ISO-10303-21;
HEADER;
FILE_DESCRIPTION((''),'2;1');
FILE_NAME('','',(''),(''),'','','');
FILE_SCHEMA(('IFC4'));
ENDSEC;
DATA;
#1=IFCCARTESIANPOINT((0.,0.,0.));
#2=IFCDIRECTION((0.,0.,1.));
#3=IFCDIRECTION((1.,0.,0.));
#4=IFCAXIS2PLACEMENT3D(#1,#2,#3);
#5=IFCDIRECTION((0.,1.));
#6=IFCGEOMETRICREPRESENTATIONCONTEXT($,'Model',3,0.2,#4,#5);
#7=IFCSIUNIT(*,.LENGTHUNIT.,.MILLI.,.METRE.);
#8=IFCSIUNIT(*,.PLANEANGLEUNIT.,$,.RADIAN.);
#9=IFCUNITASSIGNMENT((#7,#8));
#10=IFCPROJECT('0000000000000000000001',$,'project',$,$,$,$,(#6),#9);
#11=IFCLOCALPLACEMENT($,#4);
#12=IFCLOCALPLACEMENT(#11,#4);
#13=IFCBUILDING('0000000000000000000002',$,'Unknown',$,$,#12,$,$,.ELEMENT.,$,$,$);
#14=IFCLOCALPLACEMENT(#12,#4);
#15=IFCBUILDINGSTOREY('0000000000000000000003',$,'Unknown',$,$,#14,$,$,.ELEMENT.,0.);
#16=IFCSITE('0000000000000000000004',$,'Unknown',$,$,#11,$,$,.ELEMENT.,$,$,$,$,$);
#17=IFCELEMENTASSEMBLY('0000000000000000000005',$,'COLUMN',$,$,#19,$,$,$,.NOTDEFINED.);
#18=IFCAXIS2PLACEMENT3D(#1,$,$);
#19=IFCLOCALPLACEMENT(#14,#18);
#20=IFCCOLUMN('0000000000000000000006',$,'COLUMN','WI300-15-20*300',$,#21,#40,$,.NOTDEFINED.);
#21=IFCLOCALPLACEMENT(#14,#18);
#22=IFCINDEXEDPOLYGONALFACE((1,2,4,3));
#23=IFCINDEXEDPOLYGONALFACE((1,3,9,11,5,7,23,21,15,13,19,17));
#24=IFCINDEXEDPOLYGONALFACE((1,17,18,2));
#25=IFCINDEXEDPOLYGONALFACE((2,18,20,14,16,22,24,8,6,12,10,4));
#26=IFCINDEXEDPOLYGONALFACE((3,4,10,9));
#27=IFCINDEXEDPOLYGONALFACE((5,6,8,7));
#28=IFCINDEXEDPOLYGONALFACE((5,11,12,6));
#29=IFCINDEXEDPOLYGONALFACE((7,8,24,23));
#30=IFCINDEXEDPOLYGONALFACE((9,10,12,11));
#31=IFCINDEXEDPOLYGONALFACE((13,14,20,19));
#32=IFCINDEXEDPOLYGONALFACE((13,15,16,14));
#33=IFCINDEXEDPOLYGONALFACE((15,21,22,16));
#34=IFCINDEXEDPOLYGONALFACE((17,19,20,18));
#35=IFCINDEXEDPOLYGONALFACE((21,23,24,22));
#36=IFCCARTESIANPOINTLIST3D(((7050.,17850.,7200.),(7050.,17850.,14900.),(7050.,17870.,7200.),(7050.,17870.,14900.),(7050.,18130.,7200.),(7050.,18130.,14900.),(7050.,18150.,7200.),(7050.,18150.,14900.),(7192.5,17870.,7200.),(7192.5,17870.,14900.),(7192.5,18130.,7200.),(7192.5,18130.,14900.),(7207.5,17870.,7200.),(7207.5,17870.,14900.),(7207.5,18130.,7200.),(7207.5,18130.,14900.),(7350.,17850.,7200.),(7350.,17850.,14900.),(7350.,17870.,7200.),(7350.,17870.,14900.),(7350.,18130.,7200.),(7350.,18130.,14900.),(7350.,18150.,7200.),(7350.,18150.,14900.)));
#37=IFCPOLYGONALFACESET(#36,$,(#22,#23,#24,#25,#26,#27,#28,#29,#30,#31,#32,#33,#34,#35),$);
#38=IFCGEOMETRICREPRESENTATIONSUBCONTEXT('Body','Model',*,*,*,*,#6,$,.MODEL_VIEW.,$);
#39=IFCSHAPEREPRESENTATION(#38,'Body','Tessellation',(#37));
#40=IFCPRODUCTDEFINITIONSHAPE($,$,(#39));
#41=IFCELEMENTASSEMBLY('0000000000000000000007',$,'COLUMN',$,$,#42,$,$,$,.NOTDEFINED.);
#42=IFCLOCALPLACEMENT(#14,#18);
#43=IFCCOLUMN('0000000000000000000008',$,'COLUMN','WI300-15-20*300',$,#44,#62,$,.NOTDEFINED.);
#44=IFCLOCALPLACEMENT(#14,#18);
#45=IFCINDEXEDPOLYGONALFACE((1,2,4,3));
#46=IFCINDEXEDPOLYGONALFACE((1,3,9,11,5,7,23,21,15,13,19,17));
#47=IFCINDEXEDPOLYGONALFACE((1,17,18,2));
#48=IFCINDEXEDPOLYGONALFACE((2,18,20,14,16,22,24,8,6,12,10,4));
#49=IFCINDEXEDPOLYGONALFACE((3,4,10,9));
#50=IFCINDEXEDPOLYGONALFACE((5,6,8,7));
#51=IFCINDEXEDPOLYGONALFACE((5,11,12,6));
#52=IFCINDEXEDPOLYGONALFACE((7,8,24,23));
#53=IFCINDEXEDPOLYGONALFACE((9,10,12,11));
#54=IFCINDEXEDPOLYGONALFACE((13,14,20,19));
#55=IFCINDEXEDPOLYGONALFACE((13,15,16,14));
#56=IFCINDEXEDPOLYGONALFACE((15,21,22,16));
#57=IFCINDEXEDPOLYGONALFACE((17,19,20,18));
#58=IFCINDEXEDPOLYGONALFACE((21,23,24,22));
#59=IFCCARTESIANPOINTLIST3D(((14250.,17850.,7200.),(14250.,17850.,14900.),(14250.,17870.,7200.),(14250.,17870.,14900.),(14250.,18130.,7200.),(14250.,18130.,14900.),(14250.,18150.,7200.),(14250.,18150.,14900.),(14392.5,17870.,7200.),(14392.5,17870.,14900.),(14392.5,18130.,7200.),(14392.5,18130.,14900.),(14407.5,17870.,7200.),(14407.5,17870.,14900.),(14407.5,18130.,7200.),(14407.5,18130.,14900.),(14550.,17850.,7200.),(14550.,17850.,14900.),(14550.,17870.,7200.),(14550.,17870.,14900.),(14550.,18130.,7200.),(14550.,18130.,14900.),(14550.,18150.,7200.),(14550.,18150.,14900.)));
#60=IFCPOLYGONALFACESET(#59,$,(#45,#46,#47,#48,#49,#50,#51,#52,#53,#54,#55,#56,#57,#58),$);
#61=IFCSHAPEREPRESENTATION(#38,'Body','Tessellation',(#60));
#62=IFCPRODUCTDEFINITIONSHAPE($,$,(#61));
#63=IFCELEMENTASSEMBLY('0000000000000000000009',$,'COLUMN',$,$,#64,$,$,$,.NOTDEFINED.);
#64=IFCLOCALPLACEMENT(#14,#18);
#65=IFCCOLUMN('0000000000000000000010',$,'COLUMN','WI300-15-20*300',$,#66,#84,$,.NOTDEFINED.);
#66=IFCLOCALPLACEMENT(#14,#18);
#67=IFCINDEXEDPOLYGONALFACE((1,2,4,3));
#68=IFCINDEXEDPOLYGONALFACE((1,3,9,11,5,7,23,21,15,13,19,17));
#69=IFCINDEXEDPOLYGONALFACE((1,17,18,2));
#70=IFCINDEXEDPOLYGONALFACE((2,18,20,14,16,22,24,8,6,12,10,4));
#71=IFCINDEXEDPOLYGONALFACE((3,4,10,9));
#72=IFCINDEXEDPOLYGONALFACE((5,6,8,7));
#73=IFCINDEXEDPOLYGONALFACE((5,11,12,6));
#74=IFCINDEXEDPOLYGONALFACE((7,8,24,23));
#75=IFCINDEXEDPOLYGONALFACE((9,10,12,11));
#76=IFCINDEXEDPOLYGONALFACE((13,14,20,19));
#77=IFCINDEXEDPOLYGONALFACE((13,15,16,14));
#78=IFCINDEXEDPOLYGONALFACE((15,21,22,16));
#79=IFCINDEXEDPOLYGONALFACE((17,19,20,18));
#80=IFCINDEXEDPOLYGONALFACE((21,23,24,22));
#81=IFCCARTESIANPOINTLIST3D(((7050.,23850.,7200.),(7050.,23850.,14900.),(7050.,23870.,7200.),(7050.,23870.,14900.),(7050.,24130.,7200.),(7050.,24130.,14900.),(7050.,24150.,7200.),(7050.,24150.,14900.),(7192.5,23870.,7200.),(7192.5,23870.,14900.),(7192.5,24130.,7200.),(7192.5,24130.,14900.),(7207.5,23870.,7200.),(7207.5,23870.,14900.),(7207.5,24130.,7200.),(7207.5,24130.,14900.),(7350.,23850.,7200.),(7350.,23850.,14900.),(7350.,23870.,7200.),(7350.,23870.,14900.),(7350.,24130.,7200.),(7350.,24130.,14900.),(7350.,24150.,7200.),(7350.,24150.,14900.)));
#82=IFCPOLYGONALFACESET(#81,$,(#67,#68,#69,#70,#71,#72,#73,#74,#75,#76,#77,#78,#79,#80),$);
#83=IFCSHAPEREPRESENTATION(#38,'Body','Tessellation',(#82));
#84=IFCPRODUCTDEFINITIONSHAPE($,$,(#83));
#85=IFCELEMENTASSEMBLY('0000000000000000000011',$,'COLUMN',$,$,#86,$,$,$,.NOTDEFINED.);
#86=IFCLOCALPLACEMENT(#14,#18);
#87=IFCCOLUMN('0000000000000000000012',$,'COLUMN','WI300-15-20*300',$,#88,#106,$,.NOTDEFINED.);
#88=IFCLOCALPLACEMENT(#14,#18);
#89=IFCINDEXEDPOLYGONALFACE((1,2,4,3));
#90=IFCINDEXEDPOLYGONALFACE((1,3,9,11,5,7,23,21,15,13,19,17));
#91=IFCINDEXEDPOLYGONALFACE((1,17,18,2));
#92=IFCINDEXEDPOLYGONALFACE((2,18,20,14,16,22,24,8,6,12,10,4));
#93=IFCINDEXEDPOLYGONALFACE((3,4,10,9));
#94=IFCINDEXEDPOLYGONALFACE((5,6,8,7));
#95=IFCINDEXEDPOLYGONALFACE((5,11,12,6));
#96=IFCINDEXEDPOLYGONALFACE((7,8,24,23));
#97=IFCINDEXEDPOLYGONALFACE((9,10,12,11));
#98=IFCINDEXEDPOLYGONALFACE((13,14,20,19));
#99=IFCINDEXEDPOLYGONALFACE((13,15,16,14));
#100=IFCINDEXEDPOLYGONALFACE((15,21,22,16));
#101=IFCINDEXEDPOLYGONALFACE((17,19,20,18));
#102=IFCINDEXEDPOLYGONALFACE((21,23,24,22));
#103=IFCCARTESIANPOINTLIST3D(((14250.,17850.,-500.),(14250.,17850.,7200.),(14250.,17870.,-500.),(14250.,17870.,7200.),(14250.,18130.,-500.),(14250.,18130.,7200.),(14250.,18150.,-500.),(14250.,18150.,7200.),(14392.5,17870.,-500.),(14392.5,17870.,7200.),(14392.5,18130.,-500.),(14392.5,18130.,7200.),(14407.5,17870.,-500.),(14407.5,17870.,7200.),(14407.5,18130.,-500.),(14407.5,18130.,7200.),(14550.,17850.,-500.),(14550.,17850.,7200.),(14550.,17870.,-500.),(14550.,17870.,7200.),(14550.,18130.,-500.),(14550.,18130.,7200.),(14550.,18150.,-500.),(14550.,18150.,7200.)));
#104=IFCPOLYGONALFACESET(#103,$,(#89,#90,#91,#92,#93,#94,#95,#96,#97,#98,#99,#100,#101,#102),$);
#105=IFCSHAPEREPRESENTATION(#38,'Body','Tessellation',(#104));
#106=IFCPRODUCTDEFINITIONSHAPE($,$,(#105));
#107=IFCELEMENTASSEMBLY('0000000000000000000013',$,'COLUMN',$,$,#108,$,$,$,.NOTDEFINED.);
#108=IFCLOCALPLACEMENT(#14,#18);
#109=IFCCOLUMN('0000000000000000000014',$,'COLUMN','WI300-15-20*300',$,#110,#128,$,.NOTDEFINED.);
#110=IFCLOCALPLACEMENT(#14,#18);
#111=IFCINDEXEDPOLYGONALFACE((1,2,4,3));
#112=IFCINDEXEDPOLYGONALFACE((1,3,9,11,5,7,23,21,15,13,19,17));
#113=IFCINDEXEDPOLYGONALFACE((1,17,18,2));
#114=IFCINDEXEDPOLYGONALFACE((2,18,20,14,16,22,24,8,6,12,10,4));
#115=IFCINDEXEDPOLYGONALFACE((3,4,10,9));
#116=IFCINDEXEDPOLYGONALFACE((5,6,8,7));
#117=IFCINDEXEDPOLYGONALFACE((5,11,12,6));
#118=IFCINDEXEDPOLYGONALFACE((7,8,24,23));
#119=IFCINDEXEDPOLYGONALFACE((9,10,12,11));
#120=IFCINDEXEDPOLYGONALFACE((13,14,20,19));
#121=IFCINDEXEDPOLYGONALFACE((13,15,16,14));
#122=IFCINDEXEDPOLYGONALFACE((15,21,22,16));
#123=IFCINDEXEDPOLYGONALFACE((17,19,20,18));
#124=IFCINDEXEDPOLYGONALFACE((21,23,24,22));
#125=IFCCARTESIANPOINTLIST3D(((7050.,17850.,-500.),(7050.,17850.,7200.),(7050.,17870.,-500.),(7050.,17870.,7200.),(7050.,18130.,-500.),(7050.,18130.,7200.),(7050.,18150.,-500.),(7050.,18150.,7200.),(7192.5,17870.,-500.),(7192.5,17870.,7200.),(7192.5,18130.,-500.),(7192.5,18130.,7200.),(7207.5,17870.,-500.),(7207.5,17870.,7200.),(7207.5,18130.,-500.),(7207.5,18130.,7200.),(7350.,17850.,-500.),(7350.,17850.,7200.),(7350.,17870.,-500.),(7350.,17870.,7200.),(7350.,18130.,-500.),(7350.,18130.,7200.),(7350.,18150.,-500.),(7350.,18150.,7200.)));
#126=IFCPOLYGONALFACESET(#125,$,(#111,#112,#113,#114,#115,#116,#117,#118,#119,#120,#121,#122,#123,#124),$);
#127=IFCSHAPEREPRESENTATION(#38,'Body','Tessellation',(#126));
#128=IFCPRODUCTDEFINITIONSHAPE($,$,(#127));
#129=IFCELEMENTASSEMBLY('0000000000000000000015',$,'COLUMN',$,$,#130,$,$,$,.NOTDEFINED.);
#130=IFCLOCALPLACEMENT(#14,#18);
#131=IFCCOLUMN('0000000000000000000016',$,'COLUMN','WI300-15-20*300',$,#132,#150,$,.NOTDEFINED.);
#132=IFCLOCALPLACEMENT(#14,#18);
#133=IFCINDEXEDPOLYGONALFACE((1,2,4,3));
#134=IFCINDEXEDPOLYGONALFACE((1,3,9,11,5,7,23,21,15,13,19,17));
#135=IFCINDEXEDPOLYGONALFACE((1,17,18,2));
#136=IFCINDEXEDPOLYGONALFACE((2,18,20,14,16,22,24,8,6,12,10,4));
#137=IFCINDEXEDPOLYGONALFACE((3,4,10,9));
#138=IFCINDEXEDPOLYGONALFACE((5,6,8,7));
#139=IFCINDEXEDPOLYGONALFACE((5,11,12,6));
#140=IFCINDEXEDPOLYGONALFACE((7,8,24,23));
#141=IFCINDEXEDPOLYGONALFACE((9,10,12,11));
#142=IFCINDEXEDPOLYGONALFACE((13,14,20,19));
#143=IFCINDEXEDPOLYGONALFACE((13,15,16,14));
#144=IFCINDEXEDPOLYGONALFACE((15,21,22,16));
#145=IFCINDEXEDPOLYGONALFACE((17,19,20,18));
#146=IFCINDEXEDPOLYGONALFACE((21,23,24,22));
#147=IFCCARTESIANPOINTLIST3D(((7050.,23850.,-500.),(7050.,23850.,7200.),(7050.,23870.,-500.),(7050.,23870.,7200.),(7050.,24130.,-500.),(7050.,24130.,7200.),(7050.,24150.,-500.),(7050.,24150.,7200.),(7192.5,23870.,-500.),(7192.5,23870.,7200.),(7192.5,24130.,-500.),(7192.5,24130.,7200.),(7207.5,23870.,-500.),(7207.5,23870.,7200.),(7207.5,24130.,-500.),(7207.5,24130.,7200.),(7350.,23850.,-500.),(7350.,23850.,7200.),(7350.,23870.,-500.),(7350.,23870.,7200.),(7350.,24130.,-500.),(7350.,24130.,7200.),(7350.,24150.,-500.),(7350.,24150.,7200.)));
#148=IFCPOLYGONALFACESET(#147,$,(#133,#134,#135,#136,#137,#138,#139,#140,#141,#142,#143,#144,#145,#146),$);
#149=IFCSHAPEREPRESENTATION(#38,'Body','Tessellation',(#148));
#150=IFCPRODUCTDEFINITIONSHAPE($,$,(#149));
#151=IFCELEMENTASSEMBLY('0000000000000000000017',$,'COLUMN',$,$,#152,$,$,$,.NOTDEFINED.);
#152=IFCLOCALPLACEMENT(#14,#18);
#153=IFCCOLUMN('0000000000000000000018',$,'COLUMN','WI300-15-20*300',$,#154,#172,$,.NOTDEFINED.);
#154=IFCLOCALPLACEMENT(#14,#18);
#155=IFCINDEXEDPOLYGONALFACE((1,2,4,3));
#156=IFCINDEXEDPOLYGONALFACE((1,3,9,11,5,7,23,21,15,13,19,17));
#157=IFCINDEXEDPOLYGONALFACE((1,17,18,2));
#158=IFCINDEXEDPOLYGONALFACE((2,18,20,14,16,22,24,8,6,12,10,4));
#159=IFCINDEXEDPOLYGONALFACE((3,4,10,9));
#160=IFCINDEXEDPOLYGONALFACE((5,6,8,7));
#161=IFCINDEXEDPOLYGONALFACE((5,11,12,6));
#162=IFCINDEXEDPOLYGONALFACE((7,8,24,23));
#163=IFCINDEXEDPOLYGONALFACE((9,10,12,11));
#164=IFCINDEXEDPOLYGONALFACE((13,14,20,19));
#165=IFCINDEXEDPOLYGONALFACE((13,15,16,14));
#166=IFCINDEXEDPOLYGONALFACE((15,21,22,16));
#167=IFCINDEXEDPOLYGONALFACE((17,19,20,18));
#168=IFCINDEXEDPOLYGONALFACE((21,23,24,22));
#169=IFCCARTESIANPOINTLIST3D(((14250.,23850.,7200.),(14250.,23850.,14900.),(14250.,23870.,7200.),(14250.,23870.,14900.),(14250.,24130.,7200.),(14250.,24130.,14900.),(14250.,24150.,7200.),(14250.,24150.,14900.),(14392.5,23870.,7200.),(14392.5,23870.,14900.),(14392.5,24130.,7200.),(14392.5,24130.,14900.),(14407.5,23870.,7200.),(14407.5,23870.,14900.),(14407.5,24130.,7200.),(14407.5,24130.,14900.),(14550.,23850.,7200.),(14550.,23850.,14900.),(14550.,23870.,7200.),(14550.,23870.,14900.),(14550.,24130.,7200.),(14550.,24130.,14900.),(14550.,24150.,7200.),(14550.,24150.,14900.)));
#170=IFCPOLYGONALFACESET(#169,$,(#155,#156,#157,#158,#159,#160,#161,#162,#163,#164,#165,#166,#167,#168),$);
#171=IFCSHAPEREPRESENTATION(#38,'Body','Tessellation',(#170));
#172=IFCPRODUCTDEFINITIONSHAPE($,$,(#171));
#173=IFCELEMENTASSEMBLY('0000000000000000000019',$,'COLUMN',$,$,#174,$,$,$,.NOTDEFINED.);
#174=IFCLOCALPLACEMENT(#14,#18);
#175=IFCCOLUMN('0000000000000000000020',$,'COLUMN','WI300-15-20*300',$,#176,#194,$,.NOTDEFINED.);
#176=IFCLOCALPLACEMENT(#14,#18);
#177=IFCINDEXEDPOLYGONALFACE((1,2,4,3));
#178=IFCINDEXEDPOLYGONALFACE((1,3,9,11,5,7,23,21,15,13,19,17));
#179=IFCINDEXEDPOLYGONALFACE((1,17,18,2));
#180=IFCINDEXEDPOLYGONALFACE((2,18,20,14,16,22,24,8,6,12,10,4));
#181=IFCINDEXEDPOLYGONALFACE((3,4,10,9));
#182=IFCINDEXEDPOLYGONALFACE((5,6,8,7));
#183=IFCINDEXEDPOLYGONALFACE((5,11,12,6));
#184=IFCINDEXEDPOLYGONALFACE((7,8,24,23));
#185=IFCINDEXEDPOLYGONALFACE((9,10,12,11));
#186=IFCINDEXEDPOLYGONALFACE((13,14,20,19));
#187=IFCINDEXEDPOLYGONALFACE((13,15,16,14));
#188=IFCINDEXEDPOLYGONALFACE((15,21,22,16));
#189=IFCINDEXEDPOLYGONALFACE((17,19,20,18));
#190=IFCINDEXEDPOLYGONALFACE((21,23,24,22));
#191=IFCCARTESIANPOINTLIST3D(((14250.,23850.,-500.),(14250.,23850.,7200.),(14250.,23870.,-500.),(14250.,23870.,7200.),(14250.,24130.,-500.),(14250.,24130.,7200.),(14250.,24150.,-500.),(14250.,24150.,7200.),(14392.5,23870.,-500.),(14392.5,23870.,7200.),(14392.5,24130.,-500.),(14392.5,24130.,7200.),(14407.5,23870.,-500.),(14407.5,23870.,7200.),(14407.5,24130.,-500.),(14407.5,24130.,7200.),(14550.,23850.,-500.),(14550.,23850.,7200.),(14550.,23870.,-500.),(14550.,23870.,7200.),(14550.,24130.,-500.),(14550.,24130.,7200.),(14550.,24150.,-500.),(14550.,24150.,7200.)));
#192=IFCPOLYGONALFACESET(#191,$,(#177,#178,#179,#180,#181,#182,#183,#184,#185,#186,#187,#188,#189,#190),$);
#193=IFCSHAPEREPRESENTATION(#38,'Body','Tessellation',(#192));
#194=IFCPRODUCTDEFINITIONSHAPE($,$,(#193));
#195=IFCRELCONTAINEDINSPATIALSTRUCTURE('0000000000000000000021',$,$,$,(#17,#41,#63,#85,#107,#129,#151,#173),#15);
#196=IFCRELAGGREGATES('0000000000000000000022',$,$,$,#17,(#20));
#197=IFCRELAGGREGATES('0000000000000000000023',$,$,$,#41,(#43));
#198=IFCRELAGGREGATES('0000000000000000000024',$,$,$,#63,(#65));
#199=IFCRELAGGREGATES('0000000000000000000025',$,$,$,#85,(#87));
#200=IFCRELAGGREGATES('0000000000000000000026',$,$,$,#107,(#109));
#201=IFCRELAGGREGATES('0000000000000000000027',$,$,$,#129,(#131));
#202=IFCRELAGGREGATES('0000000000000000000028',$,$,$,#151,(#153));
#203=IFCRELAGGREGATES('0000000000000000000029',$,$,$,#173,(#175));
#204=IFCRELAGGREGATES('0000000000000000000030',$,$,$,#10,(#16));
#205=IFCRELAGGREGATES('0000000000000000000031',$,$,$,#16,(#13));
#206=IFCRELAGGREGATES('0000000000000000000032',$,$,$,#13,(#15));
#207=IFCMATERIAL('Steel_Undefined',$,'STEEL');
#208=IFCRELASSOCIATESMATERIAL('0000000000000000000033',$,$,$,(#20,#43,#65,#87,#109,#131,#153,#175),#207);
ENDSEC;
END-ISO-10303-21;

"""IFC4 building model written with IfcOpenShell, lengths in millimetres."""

from ifc_helpers import new_model, si_unit, direction, frame, origin_with_axes, place, context, subcontext, project, spatial, line, indexed_curve, outline, extrude, material, element, aggregate, save


model = new_model("IFC4")

# Units and contexts
model_context = context("Model", 3, precision=0.2, world=origin_with_axes(), true_north=direction((0.0, 1.0)))
body_context = subcontext(model_context, "Body", "Model", "MODEL_VIEW")
ifc_project = project(units=[si_unit("LENGTHUNIT", "METRE", prefix="MILLI"), si_unit("PLANEANGLEUNIT", "RADIAN")], contexts=[model_context])

# Site, building, storey
site_placement = place(None, origin_with_axes())
site = spatial("IfcSite", under=ifc_project, at=site_placement, Name="Unknown", CompositionType="ELEMENT")
building_placement = place(site_placement, origin_with_axes())
building = spatial("IfcBuilding", under=site, at=building_placement, Name="Unknown", CompositionType="ELEMENT")
storey_placement = place(building_placement, origin_with_axes())
storey = spatial("IfcBuildingStorey", under=building, at=storey_placement, Name="Unknown", CompositionType="ELEMENT", Elevation=0.0)

# Element assemblies, columns
assembly_1_placement = place(storey_placement, frame((7200.0, 18000.0, 7200.0), z_axis=(-1.0, 0.0, 0.0), x_axis=(0.0, 0.0, 1.0)))
assembly_1 = element("IfcElementAssembly", 1, at=assembly_1_placement, inside=storey, Name="COLUMN", PredefinedType="NOTDEFINED")
ifc_material = material(Name="Steel_Undefined", Category="STEEL")
column_1_placement = place(assembly_1_placement, origin_with_axes())
column_1 = element("IfcColumn", 2, at=column_1_placement, material=ifc_material, Name="COLUMN", Description="WI300-15-20*300", PredefinedType="NOTDEFINED", context=body_context, shape_type="SolidModel", body=[
    extrude(outline(indexed_curve([(-150.0, -150.0), (150.0, -150.0), (150.0, -130.0), (7.5, -130.0), (7.5, 130.0), (150.0, 130.0), (150.0, 150.0), (-150.0, 150.0), (-150.0, 130.0), (-7.5, 130.0), (-7.5, -130.0), (-150.0, -130.0)], segments=[line(1, 2, 3, 4, 5, 6, 7, 8, 9, 10, 11, 12, 1)])), frame((0.0, 0.0, 0.0), z_axis=(-1.0, 0.0, 0.0), x_axis=(0.0, 0.0, 1.0)), (0.0, 0.0, -1.0), 7700.0),
])
aggregate(assembly_1, [column_1])
assembly_2_placement = place(storey_placement, frame((14400.0, 18000.0, 7200.0), z_axis=(-1.0, 0.0, 0.0), x_axis=(0.0, 0.0, 1.0)))
assembly_2 = element("IfcElementAssembly", 3, at=assembly_2_placement, inside=storey, Name="COLUMN", PredefinedType="NOTDEFINED")
column_2_placement = place(assembly_2_placement, origin_with_axes())
column_2 = element("IfcColumn", 4, at=column_2_placement, material=ifc_material, Name="COLUMN", Description="WI300-15-20*300", PredefinedType="NOTDEFINED", context=body_context, shape_type="SolidModel", body=[
    extrude(outline(indexed_curve([(-150.0, -150.0), (150.0, -150.0), (150.0, -130.0), (7.5, -130.0), (7.5, 130.0), (150.0, 130.0), (150.0, 150.0), (-150.0, 150.0), (-150.0, 130.0), (-7.5, 130.0), (-7.5, -130.0), (-150.0, -130.0)], segments=[line(1, 2, 3, 4, 5, 6, 7, 8, 9, 10, 11, 12, 1)])), frame((0.0, 0.0, 0.0), z_axis=(-1.0, 0.0, 0.0), x_axis=(0.0, 0.0, 1.0)), (0.0, 0.0, -1.0), 7700.0),
])
aggregate(assembly_2, [column_2])
assembly_3_placement = place(storey_placement, frame((7200.0, 24000.0, 7200.0), z_axis=(-1.0, 0.0, 0.0), x_axis=(0.0, 0.0, 1.0)))
assembly_3 = element("IfcElementAssembly", 5, at=assembly_3_placement, inside=storey, Name="COLUMN", PredefinedType="NOTDEFINED")
column_3_placement = place(assembly_3_placement, origin_with_axes())
column_3 = element("IfcColumn", 6, at=column_3_placement, material=ifc_material, Name="COLUMN", Description="WI300-15-20*300", PredefinedType="NOTDEFINED", context=body_context, shape_type="SolidModel", body=[
    extrude(outline(indexed_curve([(-150.0, -150.0), (150.0, -150.0), (150.0, -130.0), (7.5, -130.0), (7.5, 130.0), (150.0, 130.0), (150.0, 150.0), (-150.0, 150.0), (-150.0, 130.0), (-7.5, 130.0), (-7.5, -130.0), (-150.0, -130.0)], segments=[line(1, 2, 3, 4, 5, 6, 7, 8, 9, 10, 11, 12, 1)])), frame((0.0, 0.0, 0.0), z_axis=(-1.0, 0.0, 0.0), x_axis=(0.0, 0.0, 1.0)), (0.0, 0.0, -1.0), 7700.0),
])
aggregate(assembly_3, [column_3])
assembly_4_placement = place(storey_placement, frame((14400.0, 18000.0, -500.0), z_axis=(-1.0, 0.0, 0.0), x_axis=(0.0, 0.0, 1.0)))
assembly_4 = element("IfcElementAssembly", 7, at=assembly_4_placement, inside=storey, Name="COLUMN", PredefinedType="NOTDEFINED")
column_4_placement = place(assembly_4_placement, origin_with_axes())
column_4 = element("IfcColumn", 8, at=column_4_placement, material=ifc_material, Name="COLUMN", Description="WI300-15-20*300", PredefinedType="NOTDEFINED", context=body_context, shape_type="SolidModel", body=[
    extrude(outline(indexed_curve([(-150.0, -150.0), (150.0, -150.0), (150.0, -130.0), (7.5, -130.0), (7.5, 130.0), (150.0, 130.0), (150.0, 150.0), (-150.0, 150.0), (-150.0, 130.0), (-7.5, 130.0), (-7.5, -130.0), (-150.0, -130.0)], segments=[line(1, 2, 3, 4, 5, 6, 7, 8, 9, 10, 11, 12, 1)])), frame((0.0, 0.0, 0.0), z_axis=(-1.0, 0.0, 0.0), x_axis=(0.0, 0.0, 1.0)), (0.0, 0.0, -1.0), 7700.0),
])
aggregate(assembly_4, [column_4])
assembly_5_placement = place(storey_placement, frame((7200.0, 18000.0, -500.0), z_axis=(-1.0, 0.0, 0.0), x_axis=(0.0, 0.0, 1.0)))
assembly_5 = element("IfcElementAssembly", 9, at=assembly_5_placement, inside=storey, Name="COLUMN", PredefinedType="NOTDEFINED")
column_5_placement = place(assembly_5_placement, origin_with_axes())
column_5 = element("IfcColumn", 10, at=column_5_placement, material=ifc_material, Name="COLUMN", Description="WI300-15-20*300", PredefinedType="NOTDEFINED", context=body_context, shape_type="SolidModel", body=[
    extrude(outline(indexed_curve([(-150.0, -150.0), (150.0, -150.0), (150.0, -130.0), (7.5, -130.0), (7.5, 130.0), (150.0, 130.0), (150.0, 150.0), (-150.0, 150.0), (-150.0, 130.0), (-7.5, 130.0), (-7.5, -130.0), (-150.0, -130.0)], segments=[line(1, 2, 3, 4, 5, 6, 7, 8, 9, 10, 11, 12, 1)])), frame((0.0, 0.0, 0.0), z_axis=(-1.0, 0.0, 0.0), x_axis=(0.0, 0.0, 1.0)), (0.0, 0.0, -1.0), 7700.0),
])
aggregate(assembly_5, [column_5])
assembly_6_placement = place(storey_placement, frame((7200.0, 24000.0, -500.0), z_axis=(-1.0, 0.0, 0.0), x_axis=(0.0, 0.0, 1.0)))
assembly_6 = element("IfcElementAssembly", 11, at=assembly_6_placement, inside=storey, Name="COLUMN", PredefinedType="NOTDEFINED")
column_6_placement = place(assembly_6_placement, origin_with_axes())
column_6 = element("IfcColumn", 12, at=column_6_placement, material=ifc_material, Name="COLUMN", Description="WI300-15-20*300", PredefinedType="NOTDEFINED", context=body_context, shape_type="SolidModel", body=[
    extrude(outline(indexed_curve([(-150.0, -150.0), (150.0, -150.0), (150.0, -130.0), (7.5, -130.0), (7.5, 130.0), (150.0, 130.0), (150.0, 150.0), (-150.0, 150.0), (-150.0, 130.0), (-7.5, 130.0), (-7.5, -130.0), (-150.0, -130.0)], segments=[line(1, 2, 3, 4, 5, 6, 7, 8, 9, 10, 11, 12, 1)])), frame((0.0, 0.0, 0.0), z_axis=(-1.0, 0.0, 0.0), x_axis=(0.0, 0.0, 1.0)), (0.0, 0.0, -1.0), 7700.0),
])
aggregate(assembly_6, [column_6])
assembly_7_placement = place(storey_placement, frame((14400.0, 24000.0, 7200.0), z_axis=(-1.0, 0.0, 0.0), x_axis=(0.0, 0.0, 1.0)))
assembly_7 = element("IfcElementAssembly", 13, at=assembly_7_placement, inside=storey, Name="COLUMN", PredefinedType="NOTDEFINED")
column_7_placement = place(assembly_7_placement, origin_with_axes())
column_7 = element("IfcColumn", 14, at=column_7_placement, material=ifc_material, Name="COLUMN", Description="WI300-15-20*300", PredefinedType="NOTDEFINED", context=body_context, shape_type="SolidModel", body=[
    extrude(outline(indexed_curve([(-150.0, -150.0), (150.0, -150.0), (150.0, -130.0), (7.5, -130.0), (7.5, 130.0), (150.0, 130.0), (150.0, 150.0), (-150.0, 150.0), (-150.0, 130.0), (-7.5, 130.0), (-7.5, -130.0), (-150.0, -130.0)], segments=[line(1, 2, 3, 4, 5, 6, 7, 8, 9, 10, 11, 12, 1)])), frame((0.0, 0.0, 0.0), z_axis=(-1.0, 0.0, 0.0), x_axis=(0.0, 0.0, 1.0)), (0.0, 0.0, -1.0), 7700.0),
])
aggregate(assembly_7, [column_7])
assembly_8_placement = place(storey_placement, frame((14400.0, 24000.0, -500.0), z_axis=(-1.0, 0.0, 0.0), x_axis=(0.0, 0.0, 1.0)))
assembly_8 = element("IfcElementAssembly", 15, at=assembly_8_placement, inside=storey, Name="COLUMN", PredefinedType="NOTDEFINED")
column_8_placement = place(assembly_8_placement, origin_with_axes())
column_8 = element("IfcColumn", 16, at=column_8_placement, material=ifc_material, Name="COLUMN", Description="WI300-15-20*300", PredefinedType="NOTDEFINED", context=body_context, shape_type="SolidModel", body=[
    extrude(outline(indexed_curve([(-150.0, -150.0), (150.0, -150.0), (150.0, -130.0), (7.5, -130.0), (7.5, 130.0), (150.0, 130.0), (150.0, 150.0), (-150.0, 150.0), (-150.0, 130.0), (-7.5, 130.0), (-7.5, -130.0), (-150.0, -130.0)], segments=[line(1, 2, 3, 4, 5, 6, 7, 8, 9, 10, 11, 12, 1)])), frame((0.0, 0.0, 0.0), z_axis=(-1.0, 0.0, 0.0), x_axis=(0.0, 0.0, 1.0)), (0.0, 0.0, -1.0), 7700.0),
])
aggregate(assembly_8, [column_8])

save(model, "model.ifc")
